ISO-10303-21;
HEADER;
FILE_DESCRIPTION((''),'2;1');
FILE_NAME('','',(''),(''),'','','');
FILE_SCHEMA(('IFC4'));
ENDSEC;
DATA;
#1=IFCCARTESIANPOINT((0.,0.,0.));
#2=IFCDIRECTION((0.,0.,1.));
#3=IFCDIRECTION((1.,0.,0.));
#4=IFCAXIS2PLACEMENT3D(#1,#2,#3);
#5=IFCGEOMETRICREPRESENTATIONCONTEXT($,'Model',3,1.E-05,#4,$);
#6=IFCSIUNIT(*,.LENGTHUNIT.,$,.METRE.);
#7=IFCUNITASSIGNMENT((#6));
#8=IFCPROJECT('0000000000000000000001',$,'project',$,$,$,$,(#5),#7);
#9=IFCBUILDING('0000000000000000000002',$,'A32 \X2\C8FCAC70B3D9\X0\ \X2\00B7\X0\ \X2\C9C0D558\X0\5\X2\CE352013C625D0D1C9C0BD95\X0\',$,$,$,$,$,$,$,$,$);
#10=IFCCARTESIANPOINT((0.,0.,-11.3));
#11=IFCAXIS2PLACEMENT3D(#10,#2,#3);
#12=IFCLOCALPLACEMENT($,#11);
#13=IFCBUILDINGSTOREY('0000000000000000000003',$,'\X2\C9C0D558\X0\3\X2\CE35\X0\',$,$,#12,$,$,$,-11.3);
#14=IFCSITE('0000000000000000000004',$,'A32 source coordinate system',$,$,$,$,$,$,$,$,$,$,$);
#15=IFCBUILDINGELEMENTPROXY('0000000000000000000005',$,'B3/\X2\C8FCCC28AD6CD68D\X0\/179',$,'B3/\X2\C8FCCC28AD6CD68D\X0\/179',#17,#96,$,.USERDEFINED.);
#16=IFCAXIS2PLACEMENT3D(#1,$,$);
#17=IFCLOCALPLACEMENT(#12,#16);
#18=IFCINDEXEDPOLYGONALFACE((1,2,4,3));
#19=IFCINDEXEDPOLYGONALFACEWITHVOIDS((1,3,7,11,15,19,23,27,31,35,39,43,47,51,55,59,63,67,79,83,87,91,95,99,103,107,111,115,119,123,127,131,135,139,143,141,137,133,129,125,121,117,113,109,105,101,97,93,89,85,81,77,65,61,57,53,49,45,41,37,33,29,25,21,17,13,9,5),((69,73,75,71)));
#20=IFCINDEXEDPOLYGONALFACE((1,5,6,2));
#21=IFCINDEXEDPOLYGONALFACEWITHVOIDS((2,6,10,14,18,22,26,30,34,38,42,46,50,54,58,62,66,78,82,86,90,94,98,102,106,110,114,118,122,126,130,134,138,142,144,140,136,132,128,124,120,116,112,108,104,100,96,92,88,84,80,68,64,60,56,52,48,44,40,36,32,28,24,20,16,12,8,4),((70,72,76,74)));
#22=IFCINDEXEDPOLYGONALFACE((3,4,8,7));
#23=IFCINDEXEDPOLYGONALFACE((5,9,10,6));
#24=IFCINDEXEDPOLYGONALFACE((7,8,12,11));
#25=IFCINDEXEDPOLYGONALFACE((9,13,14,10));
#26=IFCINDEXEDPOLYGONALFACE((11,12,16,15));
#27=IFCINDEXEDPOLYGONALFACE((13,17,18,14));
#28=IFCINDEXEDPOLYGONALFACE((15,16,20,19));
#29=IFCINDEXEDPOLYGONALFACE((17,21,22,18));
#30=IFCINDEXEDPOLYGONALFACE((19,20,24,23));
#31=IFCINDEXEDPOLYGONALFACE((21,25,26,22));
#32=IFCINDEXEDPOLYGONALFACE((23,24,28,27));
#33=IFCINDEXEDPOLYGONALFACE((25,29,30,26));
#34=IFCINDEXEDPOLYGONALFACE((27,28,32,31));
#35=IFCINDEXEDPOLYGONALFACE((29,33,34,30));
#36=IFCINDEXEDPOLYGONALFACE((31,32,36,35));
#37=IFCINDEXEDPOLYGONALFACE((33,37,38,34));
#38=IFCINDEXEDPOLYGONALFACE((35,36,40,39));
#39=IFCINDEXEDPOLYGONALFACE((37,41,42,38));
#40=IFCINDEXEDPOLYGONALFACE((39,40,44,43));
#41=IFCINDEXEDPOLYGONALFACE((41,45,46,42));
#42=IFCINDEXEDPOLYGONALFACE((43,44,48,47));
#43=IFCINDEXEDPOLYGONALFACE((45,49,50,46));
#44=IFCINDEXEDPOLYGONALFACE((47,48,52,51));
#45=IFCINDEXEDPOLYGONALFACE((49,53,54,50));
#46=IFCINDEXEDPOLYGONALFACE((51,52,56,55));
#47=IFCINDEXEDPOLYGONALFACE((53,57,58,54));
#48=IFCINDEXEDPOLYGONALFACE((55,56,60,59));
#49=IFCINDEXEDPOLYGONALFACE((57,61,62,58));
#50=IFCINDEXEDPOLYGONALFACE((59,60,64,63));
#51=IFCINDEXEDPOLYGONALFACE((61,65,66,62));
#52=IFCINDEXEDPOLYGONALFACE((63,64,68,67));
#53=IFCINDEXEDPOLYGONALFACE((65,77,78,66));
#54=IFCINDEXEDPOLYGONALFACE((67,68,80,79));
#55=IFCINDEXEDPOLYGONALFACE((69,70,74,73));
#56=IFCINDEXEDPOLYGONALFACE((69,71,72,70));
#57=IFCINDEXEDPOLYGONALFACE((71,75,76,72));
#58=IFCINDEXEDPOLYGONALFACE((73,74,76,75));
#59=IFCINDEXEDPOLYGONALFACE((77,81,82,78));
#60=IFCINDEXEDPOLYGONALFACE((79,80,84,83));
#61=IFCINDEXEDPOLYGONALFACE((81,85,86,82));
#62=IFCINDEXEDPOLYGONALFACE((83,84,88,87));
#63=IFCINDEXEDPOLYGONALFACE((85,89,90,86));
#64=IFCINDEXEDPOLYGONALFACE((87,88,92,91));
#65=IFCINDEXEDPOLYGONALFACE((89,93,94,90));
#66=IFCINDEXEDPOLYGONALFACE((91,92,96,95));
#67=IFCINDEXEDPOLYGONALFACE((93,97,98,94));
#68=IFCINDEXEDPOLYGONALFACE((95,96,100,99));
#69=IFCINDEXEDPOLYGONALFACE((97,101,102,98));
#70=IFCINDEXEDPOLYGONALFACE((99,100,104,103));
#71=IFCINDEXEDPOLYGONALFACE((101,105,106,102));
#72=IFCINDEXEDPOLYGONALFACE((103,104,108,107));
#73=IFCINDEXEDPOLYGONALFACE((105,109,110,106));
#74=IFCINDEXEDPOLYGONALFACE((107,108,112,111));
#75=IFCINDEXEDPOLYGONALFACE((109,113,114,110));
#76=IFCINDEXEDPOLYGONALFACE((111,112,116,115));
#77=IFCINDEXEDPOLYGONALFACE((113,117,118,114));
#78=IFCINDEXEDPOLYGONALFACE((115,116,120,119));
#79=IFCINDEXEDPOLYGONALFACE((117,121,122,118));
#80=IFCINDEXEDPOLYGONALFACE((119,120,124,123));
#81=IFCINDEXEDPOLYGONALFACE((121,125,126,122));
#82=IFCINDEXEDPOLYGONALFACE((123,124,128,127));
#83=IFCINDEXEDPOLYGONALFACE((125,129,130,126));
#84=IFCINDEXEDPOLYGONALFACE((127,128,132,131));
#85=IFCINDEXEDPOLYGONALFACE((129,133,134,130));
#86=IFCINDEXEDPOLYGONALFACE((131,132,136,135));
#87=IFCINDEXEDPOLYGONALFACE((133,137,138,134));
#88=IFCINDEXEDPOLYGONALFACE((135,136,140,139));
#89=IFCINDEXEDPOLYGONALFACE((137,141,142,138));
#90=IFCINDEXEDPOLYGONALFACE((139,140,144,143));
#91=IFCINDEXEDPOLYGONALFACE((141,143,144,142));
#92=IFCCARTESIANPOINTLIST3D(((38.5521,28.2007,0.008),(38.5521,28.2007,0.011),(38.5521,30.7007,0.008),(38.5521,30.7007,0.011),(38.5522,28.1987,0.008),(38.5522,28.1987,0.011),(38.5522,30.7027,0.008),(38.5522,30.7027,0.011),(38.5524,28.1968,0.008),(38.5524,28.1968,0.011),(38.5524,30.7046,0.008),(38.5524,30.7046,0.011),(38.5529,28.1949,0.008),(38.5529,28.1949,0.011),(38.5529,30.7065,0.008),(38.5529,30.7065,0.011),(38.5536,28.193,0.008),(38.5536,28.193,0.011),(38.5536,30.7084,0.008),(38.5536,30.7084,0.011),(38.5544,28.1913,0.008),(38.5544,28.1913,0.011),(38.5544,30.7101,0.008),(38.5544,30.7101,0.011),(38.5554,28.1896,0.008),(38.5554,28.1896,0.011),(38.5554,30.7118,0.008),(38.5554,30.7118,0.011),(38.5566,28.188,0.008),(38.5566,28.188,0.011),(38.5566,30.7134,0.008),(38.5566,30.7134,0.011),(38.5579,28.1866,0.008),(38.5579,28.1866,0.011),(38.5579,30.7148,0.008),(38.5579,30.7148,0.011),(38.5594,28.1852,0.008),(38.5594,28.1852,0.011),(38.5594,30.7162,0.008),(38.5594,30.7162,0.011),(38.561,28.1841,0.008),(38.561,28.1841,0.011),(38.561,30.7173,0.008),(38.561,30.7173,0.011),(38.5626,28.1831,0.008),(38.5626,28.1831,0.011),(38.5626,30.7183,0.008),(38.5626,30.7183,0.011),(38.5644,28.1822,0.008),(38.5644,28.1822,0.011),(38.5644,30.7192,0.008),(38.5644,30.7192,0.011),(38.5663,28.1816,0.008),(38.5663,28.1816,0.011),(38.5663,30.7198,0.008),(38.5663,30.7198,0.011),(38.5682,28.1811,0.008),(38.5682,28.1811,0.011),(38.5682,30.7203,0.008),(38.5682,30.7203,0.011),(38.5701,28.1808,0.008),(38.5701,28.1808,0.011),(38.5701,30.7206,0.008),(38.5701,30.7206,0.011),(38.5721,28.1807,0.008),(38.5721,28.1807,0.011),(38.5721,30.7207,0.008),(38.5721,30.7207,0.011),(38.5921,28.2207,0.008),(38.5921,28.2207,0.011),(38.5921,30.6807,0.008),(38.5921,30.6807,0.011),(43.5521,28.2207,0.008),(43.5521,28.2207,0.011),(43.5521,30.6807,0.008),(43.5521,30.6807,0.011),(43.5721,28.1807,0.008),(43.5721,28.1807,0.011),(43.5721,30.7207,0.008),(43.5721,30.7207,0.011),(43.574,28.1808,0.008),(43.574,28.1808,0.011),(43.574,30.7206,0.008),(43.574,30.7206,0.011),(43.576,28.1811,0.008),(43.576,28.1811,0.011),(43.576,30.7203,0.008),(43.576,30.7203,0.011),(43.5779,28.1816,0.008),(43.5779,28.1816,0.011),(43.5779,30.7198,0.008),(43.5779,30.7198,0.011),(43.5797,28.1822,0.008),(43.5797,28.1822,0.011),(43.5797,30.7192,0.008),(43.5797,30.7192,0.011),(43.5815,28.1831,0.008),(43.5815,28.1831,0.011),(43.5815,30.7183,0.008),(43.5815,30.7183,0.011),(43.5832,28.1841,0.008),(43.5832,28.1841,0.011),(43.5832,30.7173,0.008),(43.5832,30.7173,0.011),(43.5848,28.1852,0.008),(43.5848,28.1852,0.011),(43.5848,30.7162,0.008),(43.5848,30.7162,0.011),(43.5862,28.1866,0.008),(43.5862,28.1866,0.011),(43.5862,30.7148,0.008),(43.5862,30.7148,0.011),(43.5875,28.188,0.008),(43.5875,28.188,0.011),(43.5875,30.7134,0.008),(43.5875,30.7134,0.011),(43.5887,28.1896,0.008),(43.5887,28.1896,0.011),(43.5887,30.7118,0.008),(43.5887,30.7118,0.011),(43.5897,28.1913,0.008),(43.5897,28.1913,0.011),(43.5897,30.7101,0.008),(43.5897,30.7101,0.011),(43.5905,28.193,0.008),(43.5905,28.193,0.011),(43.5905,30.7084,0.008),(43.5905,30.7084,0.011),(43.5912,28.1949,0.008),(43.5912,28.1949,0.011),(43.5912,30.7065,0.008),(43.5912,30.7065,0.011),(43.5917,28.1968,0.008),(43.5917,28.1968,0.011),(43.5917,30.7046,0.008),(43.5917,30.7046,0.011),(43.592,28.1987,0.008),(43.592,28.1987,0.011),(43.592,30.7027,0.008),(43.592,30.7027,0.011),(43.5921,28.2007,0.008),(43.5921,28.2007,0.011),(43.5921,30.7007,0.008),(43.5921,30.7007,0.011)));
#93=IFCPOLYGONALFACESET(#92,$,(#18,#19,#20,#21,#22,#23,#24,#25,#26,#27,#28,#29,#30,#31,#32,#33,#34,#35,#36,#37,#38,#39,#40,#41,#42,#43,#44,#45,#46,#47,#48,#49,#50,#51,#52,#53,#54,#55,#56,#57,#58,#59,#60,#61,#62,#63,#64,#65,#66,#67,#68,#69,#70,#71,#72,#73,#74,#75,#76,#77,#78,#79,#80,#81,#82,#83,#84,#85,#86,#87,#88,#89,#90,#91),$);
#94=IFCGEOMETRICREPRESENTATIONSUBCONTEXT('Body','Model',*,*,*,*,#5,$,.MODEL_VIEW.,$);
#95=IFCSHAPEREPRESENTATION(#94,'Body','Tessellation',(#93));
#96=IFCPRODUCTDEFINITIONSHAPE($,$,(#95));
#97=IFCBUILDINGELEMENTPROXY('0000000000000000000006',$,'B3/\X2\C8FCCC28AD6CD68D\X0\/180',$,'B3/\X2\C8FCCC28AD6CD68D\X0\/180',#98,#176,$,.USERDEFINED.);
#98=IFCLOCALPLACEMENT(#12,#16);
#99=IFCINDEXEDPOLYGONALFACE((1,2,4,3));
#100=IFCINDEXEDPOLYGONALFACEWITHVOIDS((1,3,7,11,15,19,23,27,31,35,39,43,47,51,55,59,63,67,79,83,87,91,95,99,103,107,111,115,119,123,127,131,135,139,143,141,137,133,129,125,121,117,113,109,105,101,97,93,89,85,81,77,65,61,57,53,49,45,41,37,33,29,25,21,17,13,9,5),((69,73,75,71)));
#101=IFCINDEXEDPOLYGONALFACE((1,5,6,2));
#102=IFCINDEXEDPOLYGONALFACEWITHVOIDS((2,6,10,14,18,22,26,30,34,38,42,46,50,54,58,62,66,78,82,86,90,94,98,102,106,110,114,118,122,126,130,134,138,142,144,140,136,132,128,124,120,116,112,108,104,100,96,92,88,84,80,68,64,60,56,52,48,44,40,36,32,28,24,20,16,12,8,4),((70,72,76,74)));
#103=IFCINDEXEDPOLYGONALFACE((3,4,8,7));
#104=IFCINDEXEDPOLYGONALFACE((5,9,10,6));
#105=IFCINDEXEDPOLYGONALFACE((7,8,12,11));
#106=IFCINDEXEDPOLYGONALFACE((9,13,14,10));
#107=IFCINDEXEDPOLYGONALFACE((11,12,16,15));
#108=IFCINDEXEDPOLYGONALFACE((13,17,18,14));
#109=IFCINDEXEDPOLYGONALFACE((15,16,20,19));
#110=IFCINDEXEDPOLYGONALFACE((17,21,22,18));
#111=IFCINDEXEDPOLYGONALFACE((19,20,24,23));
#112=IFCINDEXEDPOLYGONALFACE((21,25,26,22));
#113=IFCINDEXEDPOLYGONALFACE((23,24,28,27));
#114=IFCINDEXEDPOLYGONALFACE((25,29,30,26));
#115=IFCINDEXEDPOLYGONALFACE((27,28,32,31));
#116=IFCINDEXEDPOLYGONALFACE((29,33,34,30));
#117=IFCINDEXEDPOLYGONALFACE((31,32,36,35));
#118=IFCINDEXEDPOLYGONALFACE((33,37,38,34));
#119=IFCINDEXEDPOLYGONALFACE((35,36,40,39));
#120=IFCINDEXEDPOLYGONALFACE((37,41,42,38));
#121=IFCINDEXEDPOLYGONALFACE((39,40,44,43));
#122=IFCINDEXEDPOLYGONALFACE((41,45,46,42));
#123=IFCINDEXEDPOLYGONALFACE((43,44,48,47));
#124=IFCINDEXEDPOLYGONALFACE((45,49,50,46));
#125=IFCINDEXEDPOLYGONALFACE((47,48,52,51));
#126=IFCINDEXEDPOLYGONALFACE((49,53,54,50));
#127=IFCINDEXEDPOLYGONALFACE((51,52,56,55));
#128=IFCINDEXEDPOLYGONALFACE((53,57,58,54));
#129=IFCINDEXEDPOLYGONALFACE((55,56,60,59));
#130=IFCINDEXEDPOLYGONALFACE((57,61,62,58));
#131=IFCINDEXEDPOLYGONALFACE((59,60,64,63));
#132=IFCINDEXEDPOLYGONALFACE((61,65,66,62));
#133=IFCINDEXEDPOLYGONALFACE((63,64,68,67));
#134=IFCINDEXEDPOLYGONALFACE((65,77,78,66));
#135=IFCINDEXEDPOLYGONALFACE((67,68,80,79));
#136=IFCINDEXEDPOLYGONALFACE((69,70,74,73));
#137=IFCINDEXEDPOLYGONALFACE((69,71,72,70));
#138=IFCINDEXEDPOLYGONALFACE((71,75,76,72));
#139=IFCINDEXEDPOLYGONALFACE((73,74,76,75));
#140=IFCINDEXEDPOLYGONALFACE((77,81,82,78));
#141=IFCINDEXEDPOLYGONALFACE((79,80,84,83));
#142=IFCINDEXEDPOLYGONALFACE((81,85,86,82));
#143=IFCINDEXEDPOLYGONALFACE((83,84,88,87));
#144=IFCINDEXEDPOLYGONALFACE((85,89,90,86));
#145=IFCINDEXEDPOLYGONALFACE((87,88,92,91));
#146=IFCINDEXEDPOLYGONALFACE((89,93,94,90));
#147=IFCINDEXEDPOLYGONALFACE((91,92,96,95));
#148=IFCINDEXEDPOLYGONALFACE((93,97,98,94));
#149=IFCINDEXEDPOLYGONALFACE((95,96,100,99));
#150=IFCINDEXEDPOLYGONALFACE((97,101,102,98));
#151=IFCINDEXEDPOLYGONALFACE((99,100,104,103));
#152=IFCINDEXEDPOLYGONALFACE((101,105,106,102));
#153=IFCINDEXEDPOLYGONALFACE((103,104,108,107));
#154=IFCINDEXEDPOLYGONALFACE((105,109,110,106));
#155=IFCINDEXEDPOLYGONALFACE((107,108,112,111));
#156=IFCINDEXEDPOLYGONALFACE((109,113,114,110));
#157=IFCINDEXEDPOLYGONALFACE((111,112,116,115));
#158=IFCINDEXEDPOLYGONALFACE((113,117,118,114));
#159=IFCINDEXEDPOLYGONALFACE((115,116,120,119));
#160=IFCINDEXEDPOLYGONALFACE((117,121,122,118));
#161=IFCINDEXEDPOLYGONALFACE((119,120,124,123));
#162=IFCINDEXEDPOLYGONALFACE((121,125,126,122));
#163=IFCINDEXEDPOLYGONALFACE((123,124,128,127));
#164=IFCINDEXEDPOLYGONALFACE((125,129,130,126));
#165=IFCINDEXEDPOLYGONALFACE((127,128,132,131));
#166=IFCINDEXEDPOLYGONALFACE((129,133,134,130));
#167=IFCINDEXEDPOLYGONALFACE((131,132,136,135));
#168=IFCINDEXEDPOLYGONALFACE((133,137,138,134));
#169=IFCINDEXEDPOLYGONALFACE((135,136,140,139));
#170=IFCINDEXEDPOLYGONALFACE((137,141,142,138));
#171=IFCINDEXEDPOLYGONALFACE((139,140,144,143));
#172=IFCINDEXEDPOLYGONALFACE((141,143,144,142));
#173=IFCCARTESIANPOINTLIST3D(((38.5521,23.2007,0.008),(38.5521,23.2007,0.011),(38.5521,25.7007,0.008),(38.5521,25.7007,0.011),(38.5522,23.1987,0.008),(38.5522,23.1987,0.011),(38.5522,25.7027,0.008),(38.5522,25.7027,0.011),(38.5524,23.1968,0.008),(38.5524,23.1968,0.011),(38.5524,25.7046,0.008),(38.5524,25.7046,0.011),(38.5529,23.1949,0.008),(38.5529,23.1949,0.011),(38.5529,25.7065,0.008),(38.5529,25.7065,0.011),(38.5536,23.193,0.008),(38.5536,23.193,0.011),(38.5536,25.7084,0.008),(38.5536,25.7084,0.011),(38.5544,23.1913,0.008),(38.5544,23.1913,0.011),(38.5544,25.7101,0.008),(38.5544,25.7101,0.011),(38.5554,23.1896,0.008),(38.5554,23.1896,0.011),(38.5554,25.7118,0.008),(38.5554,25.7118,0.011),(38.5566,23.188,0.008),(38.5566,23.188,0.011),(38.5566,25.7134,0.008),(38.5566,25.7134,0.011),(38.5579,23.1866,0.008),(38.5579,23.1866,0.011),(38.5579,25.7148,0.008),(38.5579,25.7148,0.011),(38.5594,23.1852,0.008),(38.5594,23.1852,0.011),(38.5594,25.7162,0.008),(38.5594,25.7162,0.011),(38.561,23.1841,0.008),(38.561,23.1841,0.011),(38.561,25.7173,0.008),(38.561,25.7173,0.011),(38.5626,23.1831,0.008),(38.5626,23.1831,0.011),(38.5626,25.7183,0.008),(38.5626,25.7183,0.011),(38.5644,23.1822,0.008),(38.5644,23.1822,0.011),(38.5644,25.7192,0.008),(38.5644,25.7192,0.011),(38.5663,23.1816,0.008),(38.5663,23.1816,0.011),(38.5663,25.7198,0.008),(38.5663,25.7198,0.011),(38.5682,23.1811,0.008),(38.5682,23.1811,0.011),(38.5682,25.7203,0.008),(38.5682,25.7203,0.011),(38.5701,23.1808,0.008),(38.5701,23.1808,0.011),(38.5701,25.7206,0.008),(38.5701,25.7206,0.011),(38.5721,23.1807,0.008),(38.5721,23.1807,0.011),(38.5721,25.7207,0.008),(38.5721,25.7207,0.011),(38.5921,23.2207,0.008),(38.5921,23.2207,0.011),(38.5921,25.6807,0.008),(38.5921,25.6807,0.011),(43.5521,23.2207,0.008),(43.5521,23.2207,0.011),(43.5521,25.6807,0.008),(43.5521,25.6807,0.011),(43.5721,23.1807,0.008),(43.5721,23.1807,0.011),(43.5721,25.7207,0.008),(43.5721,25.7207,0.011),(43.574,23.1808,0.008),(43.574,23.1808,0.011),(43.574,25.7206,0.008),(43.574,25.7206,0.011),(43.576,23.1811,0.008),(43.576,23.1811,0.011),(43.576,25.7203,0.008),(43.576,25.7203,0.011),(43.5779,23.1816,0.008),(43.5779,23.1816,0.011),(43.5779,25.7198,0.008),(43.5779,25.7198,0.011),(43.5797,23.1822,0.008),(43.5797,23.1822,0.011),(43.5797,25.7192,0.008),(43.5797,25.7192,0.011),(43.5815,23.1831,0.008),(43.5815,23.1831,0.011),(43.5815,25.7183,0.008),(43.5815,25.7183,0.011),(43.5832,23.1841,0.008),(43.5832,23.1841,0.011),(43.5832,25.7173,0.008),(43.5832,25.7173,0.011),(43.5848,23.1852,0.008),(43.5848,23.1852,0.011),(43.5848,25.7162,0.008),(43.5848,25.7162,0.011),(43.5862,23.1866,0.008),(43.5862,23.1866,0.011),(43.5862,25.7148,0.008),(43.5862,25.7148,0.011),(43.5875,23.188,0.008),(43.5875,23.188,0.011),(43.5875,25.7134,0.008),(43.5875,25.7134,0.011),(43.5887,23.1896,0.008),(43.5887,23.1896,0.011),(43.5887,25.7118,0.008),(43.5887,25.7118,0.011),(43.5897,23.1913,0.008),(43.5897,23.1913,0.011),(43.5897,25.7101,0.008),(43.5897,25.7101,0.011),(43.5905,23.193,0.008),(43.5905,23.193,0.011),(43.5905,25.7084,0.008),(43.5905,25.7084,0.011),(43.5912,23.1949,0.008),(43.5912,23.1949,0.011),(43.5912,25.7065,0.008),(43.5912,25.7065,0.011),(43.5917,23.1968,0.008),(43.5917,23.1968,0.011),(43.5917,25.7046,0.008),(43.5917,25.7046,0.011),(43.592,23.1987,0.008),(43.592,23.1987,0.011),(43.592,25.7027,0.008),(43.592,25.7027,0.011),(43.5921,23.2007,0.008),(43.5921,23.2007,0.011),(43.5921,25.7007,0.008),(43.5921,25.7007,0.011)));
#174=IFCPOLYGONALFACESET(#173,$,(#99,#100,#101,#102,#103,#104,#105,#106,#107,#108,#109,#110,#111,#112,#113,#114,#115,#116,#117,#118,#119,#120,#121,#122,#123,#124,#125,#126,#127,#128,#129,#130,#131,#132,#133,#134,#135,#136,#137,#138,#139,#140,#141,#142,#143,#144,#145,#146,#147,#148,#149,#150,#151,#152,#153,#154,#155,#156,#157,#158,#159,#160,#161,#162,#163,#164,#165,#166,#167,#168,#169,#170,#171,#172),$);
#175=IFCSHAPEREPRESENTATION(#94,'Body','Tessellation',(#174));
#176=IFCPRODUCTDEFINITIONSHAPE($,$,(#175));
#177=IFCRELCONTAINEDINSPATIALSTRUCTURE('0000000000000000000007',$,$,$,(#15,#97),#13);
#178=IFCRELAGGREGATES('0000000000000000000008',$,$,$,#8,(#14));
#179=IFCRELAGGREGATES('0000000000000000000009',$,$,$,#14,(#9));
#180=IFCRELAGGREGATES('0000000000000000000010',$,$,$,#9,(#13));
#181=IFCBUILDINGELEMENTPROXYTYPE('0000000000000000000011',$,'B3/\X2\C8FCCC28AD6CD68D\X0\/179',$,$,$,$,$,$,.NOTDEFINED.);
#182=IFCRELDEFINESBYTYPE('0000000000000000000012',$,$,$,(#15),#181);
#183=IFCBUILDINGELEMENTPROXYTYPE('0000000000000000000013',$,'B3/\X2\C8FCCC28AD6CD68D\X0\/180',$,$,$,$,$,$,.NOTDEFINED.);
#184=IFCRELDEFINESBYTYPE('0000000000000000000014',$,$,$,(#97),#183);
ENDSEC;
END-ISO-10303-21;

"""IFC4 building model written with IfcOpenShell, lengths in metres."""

from ifc_helpers import new_model, si_unit, frame, origin, origin_with_axes, place, context, subcontext, project, spatial, polyline, outline, extrude, source, transform, mapped, type_object, type_shapes, element, save


model = new_model("IFC4")

# Units and contexts
model_context = context("Model", 3, precision=1e-05, world=origin_with_axes())
body_context = subcontext(model_context, "Body", "Model", "MODEL_VIEW")
ifc_project = project(units=[si_unit("LENGTHUNIT", "METRE")], contexts=[model_context])

# Site, building, storey
site = spatial("IfcSite", under=ifc_project, Name="A32 source coordinate system")
building = spatial("IfcBuilding", under=site, Name="A32 주거동 · 지하5층–옥탑지붕")
storey_placement = place(None, frame((0.0, 0.0, -11.3), z_axis=(0.0, 0.0, 1.0), x_axis=(1.0, 0.0, 0.0)))
storey = spatial("IfcBuildingStorey", under=building, at=storey_placement, Name="지하3층", Elevation=-11.3)

# Building element proxies
building_element_proxy_type_1 = type_object("IfcBuildingElementProxyType", Name="B3/주차구획/179", PredefinedType="NOTDEFINED")
shared_shape_1 = source(origin(), body_context, "Body", "SweptSolid", [
    extrude(outline(polyline([(43.5721, 30.7207), (43.574, 30.7206), (43.576, 30.7203), (43.5779, 30.7198), (43.5797, 30.7192), (43.5815, 30.7183), (43.5832, 30.7173), (43.5848, 30.7162), (43.5862, 30.7148), (43.5875, 30.7134), (43.5887, 30.7118), (43.5897, 30.7101), (43.5905, 30.7084), (43.5912, 30.7065), (43.5917, 30.7046), (43.592, 30.7027), (43.5921, 30.7007), (43.5921, 28.2007), (43.592, 28.1987), (43.5917, 28.1968), (43.5912, 28.1949), (43.5905, 28.193), (43.5897, 28.1913), (43.5887, 28.1896), (43.5875, 28.188), (43.5862, 28.1866), (43.5848, 28.1852), (43.5832, 28.1841), (43.5815, 28.1831), (43.5797, 28.1822), (43.5779, 28.1816), (43.576, 28.1811), (43.574, 28.1808), (43.5721, 28.1807), (38.5721, 28.1807), (38.5701, 28.1808), (38.5682, 28.1811), (38.5663, 28.1816), (38.5644, 28.1822), (38.5626, 28.1831), (38.561, 28.1841), (38.5594, 28.1852), (38.5579, 28.1866), (38.5566, 28.188), (38.5554, 28.1896), (38.5544, 28.1913), (38.5536, 28.193), (38.5529, 28.1949), (38.5524, 28.1968), (38.5522, 28.1987), (38.5521, 28.2007), (38.5521, 30.7007), (38.5522, 30.7027), (38.5524, 30.7046), (38.5529, 30.7065), (38.5536, 30.7084), (38.5544, 30.7101), (38.5554, 30.7118), (38.5566, 30.7134), (38.5579, 30.7148), (38.5594, 30.7162), (38.561, 30.7173), (38.5626, 30.7183), (38.5644, 30.7192), (38.5663, 30.7198), (38.5682, 30.7203), (38.5701, 30.7206), (38.5721, 30.7207), (43.5721, 30.7207)]), holes=[polyline([(43.5521, 30.6807), (38.5921, 30.6807), (38.5921, 28.2207), (43.5521, 28.2207), (43.5521, 30.6807)])]), frame((0.0, 0.0, 0.008)), (0.0, 0.0, 1.0), 0.003),
])
type_shapes(building_element_proxy_type_1, [shared_shape_1])
proxy_1_placement = place(storey_placement, origin_with_axes())
element("IfcBuildingElementProxy", 1, at=proxy_1_placement, inside=storey, type_object=building_element_proxy_type_1, Name="B3/주차구획/179", ObjectType="B3/주차구획/179", PredefinedType="USERDEFINED", context=body_context, shape_type="MappedRepresentation", body=[
    mapped(shared_shape_1, transform((0.0, 0.0, 0.0), scale=1.0)),
])
building_element_proxy_type_2 = type_object("IfcBuildingElementProxyType", Name="B3/주차구획/180", PredefinedType="NOTDEFINED")
shared_shape_2 = source(origin(), body_context, "Body", "SweptSolid", [
    extrude(outline(polyline([(43.5721, 25.7207), (43.574, 25.7206), (43.576, 25.7203), (43.5779, 25.7198), (43.5797, 25.7192), (43.5815, 25.7183), (43.5832, 25.7173), (43.5848, 25.7162), (43.5862, 25.7148), (43.5875, 25.7134), (43.5887, 25.7118), (43.5897, 25.7101), (43.5905, 25.7084), (43.5912, 25.7065), (43.5917, 25.7046), (43.592, 25.7027), (43.5921, 25.7007), (43.5921, 23.2007), (43.592, 23.1987), (43.5917, 23.1968), (43.5912, 23.1949), (43.5905, 23.193), (43.5897, 23.1913), (43.5887, 23.1896), (43.5875, 23.188), (43.5862, 23.1866), (43.5848, 23.1852), (43.5832, 23.1841), (43.5815, 23.1831), (43.5797, 23.1822), (43.5779, 23.1816), (43.576, 23.1811), (43.574, 23.1808), (43.5721, 23.1807), (38.5721, 23.1807), (38.5701, 23.1808), (38.5682, 23.1811), (38.5663, 23.1816), (38.5644, 23.1822), (38.5626, 23.1831), (38.561, 23.1841), (38.5594, 23.1852), (38.5579, 23.1866), (38.5566, 23.188), (38.5554, 23.1896), (38.5544, 23.1913), (38.5536, 23.193), (38.5529, 23.1949), (38.5524, 23.1968), (38.5522, 23.1987), (38.5521, 23.2007), (38.5521, 25.7007), (38.5522, 25.7027), (38.5524, 25.7046), (38.5529, 25.7065), (38.5536, 25.7084), (38.5544, 25.7101), (38.5554, 25.7118), (38.5566, 25.7134), (38.5579, 25.7148), (38.5594, 25.7162), (38.561, 25.7173), (38.5626, 25.7183), (38.5644, 25.7192), (38.5663, 25.7198), (38.5682, 25.7203), (38.5701, 25.7206), (38.5721, 25.7207), (43.5721, 25.7207)]), holes=[polyline([(43.5521, 25.6807), (38.5921, 25.6807), (38.5921, 23.2207), (43.5521, 23.2207), (43.5521, 25.6807)])]), frame((0.0, 0.0, 0.008)), (0.0, 0.0, 1.0), 0.003),
])
type_shapes(building_element_proxy_type_2, [shared_shape_2])
proxy_2_placement = place(storey_placement, origin_with_axes())
element("IfcBuildingElementProxy", 2, at=proxy_2_placement, inside=storey, type_object=building_element_proxy_type_2, Name="B3/주차구획/180", ObjectType="B3/주차구획/180", PredefinedType="USERDEFINED", context=body_context, shape_type="MappedRepresentation", body=[
    mapped(shared_shape_2, transform((0.0, 0.0, 0.0), scale=1.0)),
])

save(model, "model.ifc")
